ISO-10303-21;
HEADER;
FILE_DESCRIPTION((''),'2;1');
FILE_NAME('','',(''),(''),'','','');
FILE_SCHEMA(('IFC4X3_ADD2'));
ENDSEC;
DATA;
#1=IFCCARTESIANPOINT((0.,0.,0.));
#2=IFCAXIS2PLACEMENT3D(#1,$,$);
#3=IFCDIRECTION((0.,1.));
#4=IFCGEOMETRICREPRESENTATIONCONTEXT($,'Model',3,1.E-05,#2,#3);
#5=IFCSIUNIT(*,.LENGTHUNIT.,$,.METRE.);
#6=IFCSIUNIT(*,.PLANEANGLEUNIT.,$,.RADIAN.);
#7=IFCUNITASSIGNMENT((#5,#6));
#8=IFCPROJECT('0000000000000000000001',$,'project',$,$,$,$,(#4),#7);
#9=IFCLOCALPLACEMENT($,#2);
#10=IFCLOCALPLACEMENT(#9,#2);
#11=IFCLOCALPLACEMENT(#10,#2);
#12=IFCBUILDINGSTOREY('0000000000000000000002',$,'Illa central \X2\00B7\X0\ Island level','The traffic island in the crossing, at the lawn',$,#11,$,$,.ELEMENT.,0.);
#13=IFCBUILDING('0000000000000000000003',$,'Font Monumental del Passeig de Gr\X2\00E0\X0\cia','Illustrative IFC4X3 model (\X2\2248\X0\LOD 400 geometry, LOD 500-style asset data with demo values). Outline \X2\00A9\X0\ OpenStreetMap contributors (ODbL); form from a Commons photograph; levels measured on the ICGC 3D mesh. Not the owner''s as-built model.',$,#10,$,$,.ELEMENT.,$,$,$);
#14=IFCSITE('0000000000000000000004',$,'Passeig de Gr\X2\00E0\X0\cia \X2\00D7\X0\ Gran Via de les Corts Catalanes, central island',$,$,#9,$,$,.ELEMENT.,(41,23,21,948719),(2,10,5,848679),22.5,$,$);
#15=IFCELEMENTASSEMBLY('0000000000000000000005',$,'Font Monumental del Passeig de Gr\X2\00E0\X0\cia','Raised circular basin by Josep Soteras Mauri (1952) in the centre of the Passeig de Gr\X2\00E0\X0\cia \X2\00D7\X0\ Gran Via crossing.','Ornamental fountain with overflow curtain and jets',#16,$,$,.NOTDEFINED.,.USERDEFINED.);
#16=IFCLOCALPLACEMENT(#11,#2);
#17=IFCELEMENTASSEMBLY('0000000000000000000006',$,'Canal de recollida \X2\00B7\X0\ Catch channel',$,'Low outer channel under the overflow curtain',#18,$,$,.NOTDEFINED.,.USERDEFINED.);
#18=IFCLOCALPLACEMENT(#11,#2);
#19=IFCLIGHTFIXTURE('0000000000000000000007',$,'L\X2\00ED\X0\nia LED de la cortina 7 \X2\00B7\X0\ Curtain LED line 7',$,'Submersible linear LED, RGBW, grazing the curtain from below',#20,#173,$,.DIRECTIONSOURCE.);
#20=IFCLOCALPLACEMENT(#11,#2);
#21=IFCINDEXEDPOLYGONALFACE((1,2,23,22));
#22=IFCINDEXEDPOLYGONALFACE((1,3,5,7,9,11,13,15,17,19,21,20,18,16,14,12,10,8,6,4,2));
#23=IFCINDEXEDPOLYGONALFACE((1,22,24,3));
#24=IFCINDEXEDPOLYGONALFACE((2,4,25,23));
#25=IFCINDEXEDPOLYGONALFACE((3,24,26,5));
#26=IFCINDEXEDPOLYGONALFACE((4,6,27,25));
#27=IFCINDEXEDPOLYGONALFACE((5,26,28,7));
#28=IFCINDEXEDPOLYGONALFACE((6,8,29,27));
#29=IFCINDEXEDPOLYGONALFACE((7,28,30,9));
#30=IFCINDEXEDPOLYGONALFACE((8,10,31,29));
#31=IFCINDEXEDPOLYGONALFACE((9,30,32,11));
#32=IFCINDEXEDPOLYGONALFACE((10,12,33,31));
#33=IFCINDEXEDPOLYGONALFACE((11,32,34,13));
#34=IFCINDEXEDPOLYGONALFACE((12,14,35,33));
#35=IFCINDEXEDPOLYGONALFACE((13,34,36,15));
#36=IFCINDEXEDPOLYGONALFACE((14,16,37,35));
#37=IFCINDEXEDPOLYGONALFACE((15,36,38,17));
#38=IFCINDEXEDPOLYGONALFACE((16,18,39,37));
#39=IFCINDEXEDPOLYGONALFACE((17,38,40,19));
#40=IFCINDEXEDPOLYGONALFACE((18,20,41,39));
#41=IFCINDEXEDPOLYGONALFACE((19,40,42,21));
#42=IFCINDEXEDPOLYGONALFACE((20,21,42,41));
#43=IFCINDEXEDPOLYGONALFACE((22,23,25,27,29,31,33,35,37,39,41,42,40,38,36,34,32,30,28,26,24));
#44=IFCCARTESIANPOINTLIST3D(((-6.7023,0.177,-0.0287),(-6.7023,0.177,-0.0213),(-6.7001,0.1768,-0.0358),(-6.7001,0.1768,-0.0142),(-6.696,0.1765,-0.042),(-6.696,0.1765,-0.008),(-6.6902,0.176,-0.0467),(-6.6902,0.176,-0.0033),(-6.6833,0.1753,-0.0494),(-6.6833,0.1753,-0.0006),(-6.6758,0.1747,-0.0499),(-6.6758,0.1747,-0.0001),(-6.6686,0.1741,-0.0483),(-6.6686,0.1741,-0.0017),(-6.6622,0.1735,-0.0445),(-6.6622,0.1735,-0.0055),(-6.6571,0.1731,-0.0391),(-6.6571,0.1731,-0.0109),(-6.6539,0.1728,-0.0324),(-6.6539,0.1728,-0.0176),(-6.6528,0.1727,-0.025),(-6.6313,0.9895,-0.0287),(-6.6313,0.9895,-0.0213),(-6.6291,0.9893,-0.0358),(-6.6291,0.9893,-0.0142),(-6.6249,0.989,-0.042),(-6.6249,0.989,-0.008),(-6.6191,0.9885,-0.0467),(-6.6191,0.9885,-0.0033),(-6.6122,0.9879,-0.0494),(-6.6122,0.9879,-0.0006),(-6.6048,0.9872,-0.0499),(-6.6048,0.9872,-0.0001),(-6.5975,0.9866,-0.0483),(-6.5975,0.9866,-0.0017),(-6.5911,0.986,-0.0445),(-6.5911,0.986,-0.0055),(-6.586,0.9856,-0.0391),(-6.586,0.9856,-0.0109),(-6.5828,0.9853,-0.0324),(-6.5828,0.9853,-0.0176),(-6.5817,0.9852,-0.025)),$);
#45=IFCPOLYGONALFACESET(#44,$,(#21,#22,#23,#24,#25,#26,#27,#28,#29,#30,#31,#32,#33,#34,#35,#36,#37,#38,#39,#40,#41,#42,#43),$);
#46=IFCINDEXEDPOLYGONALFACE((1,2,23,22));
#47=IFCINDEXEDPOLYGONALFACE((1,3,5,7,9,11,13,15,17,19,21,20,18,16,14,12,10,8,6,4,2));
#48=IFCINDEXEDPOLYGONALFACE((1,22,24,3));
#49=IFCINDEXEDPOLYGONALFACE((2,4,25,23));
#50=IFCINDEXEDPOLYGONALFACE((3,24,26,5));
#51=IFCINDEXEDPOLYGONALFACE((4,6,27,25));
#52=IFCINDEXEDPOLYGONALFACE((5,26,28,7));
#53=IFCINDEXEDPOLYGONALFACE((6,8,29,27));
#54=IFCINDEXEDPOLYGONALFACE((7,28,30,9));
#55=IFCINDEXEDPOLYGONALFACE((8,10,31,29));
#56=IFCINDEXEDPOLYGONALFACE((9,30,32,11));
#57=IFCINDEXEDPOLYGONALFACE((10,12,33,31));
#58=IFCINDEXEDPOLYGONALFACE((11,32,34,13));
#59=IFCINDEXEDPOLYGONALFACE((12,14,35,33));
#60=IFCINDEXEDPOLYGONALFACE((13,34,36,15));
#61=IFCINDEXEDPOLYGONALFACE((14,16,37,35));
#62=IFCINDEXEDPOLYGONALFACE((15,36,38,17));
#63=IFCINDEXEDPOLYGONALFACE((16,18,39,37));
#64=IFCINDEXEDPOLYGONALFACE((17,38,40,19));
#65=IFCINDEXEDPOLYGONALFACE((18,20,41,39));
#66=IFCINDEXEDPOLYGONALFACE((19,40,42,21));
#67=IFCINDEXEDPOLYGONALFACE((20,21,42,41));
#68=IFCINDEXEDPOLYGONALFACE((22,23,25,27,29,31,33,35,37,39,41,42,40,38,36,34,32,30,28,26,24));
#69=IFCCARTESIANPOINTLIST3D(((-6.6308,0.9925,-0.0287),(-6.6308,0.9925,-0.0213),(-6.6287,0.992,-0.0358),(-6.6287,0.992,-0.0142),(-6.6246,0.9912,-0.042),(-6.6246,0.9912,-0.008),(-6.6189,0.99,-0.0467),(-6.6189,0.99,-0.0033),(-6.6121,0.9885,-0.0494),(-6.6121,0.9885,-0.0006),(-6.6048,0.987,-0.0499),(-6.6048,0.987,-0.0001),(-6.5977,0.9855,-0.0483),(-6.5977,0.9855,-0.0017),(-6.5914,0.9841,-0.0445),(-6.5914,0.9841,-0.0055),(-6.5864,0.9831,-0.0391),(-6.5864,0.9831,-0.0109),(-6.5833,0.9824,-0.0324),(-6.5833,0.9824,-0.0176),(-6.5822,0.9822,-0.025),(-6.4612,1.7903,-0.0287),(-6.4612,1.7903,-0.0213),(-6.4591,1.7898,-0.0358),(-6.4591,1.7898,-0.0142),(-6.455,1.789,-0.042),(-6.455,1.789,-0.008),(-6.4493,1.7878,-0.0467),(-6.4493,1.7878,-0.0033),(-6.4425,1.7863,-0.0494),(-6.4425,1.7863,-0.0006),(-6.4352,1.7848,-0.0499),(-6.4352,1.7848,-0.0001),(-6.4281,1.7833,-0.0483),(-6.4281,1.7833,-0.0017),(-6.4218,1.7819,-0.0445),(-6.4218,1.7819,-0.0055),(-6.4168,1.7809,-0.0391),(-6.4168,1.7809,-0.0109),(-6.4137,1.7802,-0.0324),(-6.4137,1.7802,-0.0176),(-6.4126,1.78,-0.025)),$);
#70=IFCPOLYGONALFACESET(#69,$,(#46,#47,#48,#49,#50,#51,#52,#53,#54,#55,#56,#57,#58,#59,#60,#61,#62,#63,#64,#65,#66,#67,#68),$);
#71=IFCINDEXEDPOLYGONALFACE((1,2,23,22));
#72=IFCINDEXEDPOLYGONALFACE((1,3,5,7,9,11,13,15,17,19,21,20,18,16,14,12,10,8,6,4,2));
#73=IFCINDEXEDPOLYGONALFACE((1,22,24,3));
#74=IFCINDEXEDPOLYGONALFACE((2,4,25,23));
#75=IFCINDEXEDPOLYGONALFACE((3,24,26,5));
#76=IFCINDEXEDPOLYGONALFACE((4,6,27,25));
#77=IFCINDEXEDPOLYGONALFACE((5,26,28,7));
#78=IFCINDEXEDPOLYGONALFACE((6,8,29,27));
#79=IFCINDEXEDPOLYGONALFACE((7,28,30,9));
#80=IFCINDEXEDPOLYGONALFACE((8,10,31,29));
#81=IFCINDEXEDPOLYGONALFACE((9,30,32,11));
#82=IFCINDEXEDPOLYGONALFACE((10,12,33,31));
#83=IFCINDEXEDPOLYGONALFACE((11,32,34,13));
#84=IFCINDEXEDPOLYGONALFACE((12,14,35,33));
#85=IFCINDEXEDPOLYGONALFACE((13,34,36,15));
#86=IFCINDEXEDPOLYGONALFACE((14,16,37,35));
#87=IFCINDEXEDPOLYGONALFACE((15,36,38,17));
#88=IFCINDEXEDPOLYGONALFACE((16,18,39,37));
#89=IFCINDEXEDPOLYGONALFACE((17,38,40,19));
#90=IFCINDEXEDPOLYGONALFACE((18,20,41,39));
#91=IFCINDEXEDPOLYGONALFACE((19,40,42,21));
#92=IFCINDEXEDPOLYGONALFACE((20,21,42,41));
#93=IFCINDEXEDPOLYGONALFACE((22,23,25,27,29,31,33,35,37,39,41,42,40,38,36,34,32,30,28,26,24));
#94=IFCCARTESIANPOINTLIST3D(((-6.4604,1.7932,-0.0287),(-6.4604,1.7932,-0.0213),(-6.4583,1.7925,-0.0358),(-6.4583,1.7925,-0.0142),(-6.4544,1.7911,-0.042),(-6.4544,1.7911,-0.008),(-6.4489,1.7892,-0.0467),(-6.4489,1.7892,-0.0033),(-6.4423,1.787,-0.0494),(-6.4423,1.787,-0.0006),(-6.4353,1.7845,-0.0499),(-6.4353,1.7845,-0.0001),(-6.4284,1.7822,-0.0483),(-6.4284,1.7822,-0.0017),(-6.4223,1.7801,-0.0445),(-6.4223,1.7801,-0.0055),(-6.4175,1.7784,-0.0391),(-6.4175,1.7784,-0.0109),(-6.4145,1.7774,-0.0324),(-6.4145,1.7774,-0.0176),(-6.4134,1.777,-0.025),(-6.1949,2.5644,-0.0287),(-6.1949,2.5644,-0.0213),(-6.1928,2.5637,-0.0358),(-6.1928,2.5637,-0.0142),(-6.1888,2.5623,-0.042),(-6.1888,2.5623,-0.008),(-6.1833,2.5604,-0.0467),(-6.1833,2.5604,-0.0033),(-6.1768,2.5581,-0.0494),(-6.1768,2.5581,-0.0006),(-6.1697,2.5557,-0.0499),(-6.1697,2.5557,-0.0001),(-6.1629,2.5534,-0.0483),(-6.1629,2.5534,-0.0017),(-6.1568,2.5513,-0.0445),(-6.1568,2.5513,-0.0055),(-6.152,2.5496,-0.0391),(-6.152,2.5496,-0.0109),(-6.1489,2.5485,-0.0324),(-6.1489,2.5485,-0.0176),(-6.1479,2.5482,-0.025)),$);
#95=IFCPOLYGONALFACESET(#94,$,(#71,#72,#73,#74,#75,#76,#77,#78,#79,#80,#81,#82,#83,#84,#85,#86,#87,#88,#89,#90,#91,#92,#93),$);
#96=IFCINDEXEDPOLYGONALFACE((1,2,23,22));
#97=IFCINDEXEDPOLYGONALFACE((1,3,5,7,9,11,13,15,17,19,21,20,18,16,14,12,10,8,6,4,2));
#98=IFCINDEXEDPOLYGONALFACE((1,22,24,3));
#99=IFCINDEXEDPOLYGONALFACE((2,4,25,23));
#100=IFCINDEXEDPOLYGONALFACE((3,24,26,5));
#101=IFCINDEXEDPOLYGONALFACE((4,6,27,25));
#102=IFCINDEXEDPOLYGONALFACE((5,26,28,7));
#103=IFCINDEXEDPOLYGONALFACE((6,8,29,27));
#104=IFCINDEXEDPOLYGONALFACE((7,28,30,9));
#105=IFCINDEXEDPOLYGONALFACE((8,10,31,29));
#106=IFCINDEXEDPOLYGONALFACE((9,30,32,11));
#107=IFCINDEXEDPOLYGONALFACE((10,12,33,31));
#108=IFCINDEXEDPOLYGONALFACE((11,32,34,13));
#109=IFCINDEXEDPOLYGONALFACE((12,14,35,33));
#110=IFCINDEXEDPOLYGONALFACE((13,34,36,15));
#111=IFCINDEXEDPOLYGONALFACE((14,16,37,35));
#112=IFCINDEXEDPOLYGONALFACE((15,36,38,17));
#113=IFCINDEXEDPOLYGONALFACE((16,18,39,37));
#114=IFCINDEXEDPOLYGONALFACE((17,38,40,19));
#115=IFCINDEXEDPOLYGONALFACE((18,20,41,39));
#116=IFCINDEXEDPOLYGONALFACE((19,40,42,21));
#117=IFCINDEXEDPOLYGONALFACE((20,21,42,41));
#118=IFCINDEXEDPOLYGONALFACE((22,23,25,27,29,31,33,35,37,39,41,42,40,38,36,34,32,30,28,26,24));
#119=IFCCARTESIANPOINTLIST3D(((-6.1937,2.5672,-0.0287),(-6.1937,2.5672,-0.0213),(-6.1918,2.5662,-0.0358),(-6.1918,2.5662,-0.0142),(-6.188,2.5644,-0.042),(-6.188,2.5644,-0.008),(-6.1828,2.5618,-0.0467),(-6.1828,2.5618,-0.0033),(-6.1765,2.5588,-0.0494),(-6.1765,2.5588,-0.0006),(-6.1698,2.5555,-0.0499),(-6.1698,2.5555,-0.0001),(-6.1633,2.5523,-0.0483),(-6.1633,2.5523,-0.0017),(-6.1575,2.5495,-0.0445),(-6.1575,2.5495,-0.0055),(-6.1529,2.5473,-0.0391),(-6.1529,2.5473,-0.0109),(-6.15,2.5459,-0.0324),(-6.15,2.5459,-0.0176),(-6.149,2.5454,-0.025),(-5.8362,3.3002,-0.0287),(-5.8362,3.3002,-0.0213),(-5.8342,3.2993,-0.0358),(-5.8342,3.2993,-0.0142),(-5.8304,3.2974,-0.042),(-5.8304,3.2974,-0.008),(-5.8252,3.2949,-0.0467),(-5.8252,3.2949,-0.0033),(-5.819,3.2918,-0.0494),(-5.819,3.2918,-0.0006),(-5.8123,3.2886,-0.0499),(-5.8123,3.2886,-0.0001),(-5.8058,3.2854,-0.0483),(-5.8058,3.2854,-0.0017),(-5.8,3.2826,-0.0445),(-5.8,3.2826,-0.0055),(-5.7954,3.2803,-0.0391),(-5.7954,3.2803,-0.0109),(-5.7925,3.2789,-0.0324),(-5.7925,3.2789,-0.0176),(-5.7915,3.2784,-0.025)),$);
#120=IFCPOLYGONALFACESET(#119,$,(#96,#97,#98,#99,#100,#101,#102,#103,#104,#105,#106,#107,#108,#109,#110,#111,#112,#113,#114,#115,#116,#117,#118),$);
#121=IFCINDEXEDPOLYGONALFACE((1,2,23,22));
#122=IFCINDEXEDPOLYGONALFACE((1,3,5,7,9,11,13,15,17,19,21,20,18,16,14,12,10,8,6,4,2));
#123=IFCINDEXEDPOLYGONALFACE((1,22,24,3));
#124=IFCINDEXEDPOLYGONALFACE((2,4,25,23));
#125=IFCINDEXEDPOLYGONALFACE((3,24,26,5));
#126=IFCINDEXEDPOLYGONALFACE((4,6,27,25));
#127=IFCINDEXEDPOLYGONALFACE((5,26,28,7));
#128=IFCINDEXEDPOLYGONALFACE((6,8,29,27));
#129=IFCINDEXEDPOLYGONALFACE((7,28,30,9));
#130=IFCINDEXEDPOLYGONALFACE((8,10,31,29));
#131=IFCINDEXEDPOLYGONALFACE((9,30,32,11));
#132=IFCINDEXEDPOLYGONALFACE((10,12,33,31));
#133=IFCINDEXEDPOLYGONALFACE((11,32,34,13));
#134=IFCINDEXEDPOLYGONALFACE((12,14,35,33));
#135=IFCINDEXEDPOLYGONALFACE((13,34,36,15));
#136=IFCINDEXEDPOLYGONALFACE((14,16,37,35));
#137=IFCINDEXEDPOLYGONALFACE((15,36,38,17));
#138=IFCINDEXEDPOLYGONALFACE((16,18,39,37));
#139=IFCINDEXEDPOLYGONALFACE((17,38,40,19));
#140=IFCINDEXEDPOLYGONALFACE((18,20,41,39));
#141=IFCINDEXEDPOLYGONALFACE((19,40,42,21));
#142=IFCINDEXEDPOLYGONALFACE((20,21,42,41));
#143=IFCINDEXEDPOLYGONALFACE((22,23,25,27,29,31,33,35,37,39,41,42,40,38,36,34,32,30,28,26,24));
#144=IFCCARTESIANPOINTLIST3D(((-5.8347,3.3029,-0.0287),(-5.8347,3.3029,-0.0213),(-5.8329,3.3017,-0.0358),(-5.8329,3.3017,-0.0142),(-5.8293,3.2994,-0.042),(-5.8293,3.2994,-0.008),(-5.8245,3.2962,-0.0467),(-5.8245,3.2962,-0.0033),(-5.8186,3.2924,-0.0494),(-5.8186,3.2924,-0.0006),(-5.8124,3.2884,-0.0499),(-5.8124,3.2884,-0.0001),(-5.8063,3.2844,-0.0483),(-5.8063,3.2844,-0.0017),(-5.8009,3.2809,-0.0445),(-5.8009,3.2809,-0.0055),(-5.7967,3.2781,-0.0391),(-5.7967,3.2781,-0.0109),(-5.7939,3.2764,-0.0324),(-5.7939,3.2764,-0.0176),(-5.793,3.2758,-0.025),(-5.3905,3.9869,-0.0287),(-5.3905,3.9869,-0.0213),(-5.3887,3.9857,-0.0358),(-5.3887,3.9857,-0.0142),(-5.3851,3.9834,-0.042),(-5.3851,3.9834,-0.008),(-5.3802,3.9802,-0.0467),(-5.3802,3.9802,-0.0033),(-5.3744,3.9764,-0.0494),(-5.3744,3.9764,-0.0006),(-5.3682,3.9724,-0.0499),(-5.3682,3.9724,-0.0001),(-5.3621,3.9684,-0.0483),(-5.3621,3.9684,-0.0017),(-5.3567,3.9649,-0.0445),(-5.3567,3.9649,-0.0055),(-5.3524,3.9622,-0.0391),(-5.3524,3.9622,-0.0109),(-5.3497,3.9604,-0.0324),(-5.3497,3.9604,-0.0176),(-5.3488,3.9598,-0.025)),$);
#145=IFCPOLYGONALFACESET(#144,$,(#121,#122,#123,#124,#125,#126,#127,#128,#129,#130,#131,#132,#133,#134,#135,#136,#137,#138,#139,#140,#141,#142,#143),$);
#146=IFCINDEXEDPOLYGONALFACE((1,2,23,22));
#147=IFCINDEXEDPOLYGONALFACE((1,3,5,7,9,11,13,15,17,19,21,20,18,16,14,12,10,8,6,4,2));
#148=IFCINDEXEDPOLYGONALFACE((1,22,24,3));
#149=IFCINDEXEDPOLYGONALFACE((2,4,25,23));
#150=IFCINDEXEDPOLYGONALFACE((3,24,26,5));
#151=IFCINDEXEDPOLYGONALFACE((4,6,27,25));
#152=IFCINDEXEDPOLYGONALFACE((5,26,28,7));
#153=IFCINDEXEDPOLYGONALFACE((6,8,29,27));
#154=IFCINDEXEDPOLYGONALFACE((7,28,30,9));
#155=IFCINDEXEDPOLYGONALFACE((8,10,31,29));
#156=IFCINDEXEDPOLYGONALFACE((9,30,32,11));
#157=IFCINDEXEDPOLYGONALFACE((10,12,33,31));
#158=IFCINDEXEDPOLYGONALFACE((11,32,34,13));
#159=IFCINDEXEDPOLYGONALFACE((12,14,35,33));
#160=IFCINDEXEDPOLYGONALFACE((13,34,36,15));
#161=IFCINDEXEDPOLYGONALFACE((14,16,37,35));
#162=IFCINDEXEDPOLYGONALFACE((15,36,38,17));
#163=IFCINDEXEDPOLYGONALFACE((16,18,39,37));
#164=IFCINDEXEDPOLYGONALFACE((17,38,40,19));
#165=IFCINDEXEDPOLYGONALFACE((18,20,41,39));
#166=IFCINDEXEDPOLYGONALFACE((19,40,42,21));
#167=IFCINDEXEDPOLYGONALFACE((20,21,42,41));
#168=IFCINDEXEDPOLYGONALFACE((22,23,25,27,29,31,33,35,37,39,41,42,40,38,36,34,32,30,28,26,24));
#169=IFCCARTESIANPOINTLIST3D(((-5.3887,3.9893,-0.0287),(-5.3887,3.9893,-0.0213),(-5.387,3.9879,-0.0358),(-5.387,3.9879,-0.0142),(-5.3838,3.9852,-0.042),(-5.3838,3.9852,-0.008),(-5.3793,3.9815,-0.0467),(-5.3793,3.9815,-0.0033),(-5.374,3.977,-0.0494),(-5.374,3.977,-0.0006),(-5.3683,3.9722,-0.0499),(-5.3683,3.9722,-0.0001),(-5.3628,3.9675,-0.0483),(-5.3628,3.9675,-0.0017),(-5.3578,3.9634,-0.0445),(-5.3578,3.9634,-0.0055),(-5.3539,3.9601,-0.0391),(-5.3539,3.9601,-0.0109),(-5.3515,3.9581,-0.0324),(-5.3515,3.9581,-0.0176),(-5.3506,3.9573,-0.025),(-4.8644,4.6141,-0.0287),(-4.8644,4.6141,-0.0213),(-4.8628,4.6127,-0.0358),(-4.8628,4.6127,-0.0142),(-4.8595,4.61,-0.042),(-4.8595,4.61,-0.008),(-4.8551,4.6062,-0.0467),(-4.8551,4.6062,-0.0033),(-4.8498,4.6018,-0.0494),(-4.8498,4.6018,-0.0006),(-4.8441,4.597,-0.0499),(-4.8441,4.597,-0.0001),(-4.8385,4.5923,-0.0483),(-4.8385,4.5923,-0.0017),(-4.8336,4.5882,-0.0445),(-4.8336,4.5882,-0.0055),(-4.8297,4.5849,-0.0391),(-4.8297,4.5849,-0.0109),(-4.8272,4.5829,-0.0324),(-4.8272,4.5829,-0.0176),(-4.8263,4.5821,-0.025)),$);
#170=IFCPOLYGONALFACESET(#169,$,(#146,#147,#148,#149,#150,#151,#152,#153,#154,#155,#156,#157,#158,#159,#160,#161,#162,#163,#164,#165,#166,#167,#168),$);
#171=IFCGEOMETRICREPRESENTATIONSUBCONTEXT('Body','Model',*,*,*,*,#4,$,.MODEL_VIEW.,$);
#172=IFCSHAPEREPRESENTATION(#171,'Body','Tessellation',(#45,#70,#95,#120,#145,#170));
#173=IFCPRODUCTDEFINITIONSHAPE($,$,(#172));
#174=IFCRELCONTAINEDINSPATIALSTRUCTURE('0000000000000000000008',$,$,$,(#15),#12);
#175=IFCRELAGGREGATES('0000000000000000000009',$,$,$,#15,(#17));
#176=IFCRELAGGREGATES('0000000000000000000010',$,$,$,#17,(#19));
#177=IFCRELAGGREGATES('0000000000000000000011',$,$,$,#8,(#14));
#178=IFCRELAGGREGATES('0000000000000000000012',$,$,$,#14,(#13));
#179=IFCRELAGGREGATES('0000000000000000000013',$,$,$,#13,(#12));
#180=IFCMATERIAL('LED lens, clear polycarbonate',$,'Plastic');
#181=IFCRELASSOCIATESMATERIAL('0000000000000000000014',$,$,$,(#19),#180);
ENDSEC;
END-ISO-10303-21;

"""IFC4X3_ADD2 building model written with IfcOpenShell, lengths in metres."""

from ifc_helpers import new_model, si_unit, direction, frame, origin, origin_2d_with_axis, place, context, subcontext, project, spatial, circle, extrude, material, element, aggregate, save


model = new_model("IFC4X3_ADD2")

# Units and contexts
model_context = context("Model", 3, precision=1e-05, world=origin(), true_north=direction((0.0, 1.0)))
body_context = subcontext(model_context, "Body", "Model", "MODEL_VIEW")
ifc_project = project(units=[si_unit("LENGTHUNIT", "METRE"), si_unit("PLANEANGLEUNIT", "RADIAN")], contexts=[model_context])

# Site, building, storey
site_placement = place(None, origin())
site = spatial("IfcSite", under=ifc_project, at=site_placement, Name="Passeig de Gràcia × Gran Via de les Corts Catalanes, central island", CompositionType="ELEMENT", RefLatitude=(41, 23, 21, 948719), RefLongitude=(2, 10, 5, 848679), RefElevation=22.5)
building_placement = place(site_placement, origin())
building = spatial("IfcBuilding", under=site, at=building_placement, Name="Font Monumental del Passeig de Gràcia", Description="Illustrative IFC4X3 model (≈LOD 400 geometry, LOD 500-style asset data with demo values). Outline © OpenStreetMap contributors (ODbL); form from a Commons photograph; levels measured on the ICGC 3D mesh. Not the owner's as-built model.", CompositionType="ELEMENT")
storey_placement = place(building_placement, origin())
storey = spatial("IfcBuildingStorey", under=building, at=storey_placement, Name="Illa central · Island level", Description="The traffic island in the crossing, at the lawn", CompositionType="ELEMENT", Elevation=0.0)

# Element assemblies, light fixture
assembly_1_placement = place(building_placement, origin())
assembly_1 = element("IfcElementAssembly", 1, at=assembly_1_placement, inside=storey, Name="Font Monumental del Passeig de Gràcia", Description="Raised circular basin by Josep Soteras Mauri (1952) in the centre of the Passeig de Gràcia × Gran Via crossing.", ObjectType="Ornamental fountain with overflow curtain and jets", AssemblyPlace="NOTDEFINED", PredefinedType="USERDEFINED")
assembly_2_placement = place(building_placement, origin())
assembly_2 = element("IfcElementAssembly", 2, at=assembly_2_placement, Name="Canal de recollida · Catch channel", ObjectType="Low outer channel under the overflow curtain", AssemblyPlace="NOTDEFINED", PredefinedType="USERDEFINED")
ifc_material_1 = material(Name="LED lens, clear polycarbonate", Category="Plastic")
light_fixture_1_placement = place(building_placement, origin())
light_fixture_1 = element("IfcLightFixture", 3, at=light_fixture_1_placement, material=ifc_material_1, Name="Línia LED de la cortina 7 · Curtain LED line 7", ObjectType="Submersible linear LED, RGBW, grazing the curtain from below", PredefinedType="DIRECTIONSOURCE", context=body_context, shape_type="SweptSolid", body=[
    extrude(circle(Radius=0.025, at=origin_2d_with_axis()), frame((-6.6777, 0.1749, -0.025), z_axis=(0.087156, 0.996195, 0.0), x_axis=(0.996195, -0.087156, 0.0)), (0.0, 0.0, 1.0), 0.8156),
    extrude(circle(Radius=0.025, at=origin_2d_with_axis()), frame((-6.6066, 0.9874, -0.025), z_axis=(0.207912, 0.978148, 0.0), x_axis=(0.978148, -0.207912, 0.0)), (0.0, 0.0, 1.0), 0.8156),
    extrude(circle(Radius=0.025, at=origin_2d_with_axis()), frame((-6.4371, 1.7852, -0.025), z_axis=(0.325568, 0.945519, 0.0), x_axis=(0.945519, -0.325568, 0.0)), (0.0, 0.0, 1.0), 0.8156),
    extrude(circle(Radius=0.025, at=origin_2d_with_axis()), frame((-6.1715, 2.5563, -0.025), z_axis=(0.438371, 0.898794, 0.0), x_axis=(0.898794, -0.438371, 0.0)), (0.0, 0.0, 1.0), 0.8156),
    extrude(circle(Radius=0.025, at=origin_2d_with_axis()), frame((-5.814, 3.2894, -0.025), z_axis=(0.544639, 0.838671, 0.0), x_axis=(0.838671, -0.544639, 0.0)), (0.0, 0.0, 1.0), 0.8156),
    extrude(circle(Radius=0.025, at=origin_2d_with_axis()), frame((-5.3698, 3.9734, -0.025), z_axis=(0.642788, 0.766044, 0.0), x_axis=(0.766044, -0.642788, 0.0)), (0.0, 0.0, 1.0), 0.8156),
])
aggregate(assembly_1, [assembly_2])
aggregate(assembly_2, [light_fixture_1])

save(model, "model.ifc")
